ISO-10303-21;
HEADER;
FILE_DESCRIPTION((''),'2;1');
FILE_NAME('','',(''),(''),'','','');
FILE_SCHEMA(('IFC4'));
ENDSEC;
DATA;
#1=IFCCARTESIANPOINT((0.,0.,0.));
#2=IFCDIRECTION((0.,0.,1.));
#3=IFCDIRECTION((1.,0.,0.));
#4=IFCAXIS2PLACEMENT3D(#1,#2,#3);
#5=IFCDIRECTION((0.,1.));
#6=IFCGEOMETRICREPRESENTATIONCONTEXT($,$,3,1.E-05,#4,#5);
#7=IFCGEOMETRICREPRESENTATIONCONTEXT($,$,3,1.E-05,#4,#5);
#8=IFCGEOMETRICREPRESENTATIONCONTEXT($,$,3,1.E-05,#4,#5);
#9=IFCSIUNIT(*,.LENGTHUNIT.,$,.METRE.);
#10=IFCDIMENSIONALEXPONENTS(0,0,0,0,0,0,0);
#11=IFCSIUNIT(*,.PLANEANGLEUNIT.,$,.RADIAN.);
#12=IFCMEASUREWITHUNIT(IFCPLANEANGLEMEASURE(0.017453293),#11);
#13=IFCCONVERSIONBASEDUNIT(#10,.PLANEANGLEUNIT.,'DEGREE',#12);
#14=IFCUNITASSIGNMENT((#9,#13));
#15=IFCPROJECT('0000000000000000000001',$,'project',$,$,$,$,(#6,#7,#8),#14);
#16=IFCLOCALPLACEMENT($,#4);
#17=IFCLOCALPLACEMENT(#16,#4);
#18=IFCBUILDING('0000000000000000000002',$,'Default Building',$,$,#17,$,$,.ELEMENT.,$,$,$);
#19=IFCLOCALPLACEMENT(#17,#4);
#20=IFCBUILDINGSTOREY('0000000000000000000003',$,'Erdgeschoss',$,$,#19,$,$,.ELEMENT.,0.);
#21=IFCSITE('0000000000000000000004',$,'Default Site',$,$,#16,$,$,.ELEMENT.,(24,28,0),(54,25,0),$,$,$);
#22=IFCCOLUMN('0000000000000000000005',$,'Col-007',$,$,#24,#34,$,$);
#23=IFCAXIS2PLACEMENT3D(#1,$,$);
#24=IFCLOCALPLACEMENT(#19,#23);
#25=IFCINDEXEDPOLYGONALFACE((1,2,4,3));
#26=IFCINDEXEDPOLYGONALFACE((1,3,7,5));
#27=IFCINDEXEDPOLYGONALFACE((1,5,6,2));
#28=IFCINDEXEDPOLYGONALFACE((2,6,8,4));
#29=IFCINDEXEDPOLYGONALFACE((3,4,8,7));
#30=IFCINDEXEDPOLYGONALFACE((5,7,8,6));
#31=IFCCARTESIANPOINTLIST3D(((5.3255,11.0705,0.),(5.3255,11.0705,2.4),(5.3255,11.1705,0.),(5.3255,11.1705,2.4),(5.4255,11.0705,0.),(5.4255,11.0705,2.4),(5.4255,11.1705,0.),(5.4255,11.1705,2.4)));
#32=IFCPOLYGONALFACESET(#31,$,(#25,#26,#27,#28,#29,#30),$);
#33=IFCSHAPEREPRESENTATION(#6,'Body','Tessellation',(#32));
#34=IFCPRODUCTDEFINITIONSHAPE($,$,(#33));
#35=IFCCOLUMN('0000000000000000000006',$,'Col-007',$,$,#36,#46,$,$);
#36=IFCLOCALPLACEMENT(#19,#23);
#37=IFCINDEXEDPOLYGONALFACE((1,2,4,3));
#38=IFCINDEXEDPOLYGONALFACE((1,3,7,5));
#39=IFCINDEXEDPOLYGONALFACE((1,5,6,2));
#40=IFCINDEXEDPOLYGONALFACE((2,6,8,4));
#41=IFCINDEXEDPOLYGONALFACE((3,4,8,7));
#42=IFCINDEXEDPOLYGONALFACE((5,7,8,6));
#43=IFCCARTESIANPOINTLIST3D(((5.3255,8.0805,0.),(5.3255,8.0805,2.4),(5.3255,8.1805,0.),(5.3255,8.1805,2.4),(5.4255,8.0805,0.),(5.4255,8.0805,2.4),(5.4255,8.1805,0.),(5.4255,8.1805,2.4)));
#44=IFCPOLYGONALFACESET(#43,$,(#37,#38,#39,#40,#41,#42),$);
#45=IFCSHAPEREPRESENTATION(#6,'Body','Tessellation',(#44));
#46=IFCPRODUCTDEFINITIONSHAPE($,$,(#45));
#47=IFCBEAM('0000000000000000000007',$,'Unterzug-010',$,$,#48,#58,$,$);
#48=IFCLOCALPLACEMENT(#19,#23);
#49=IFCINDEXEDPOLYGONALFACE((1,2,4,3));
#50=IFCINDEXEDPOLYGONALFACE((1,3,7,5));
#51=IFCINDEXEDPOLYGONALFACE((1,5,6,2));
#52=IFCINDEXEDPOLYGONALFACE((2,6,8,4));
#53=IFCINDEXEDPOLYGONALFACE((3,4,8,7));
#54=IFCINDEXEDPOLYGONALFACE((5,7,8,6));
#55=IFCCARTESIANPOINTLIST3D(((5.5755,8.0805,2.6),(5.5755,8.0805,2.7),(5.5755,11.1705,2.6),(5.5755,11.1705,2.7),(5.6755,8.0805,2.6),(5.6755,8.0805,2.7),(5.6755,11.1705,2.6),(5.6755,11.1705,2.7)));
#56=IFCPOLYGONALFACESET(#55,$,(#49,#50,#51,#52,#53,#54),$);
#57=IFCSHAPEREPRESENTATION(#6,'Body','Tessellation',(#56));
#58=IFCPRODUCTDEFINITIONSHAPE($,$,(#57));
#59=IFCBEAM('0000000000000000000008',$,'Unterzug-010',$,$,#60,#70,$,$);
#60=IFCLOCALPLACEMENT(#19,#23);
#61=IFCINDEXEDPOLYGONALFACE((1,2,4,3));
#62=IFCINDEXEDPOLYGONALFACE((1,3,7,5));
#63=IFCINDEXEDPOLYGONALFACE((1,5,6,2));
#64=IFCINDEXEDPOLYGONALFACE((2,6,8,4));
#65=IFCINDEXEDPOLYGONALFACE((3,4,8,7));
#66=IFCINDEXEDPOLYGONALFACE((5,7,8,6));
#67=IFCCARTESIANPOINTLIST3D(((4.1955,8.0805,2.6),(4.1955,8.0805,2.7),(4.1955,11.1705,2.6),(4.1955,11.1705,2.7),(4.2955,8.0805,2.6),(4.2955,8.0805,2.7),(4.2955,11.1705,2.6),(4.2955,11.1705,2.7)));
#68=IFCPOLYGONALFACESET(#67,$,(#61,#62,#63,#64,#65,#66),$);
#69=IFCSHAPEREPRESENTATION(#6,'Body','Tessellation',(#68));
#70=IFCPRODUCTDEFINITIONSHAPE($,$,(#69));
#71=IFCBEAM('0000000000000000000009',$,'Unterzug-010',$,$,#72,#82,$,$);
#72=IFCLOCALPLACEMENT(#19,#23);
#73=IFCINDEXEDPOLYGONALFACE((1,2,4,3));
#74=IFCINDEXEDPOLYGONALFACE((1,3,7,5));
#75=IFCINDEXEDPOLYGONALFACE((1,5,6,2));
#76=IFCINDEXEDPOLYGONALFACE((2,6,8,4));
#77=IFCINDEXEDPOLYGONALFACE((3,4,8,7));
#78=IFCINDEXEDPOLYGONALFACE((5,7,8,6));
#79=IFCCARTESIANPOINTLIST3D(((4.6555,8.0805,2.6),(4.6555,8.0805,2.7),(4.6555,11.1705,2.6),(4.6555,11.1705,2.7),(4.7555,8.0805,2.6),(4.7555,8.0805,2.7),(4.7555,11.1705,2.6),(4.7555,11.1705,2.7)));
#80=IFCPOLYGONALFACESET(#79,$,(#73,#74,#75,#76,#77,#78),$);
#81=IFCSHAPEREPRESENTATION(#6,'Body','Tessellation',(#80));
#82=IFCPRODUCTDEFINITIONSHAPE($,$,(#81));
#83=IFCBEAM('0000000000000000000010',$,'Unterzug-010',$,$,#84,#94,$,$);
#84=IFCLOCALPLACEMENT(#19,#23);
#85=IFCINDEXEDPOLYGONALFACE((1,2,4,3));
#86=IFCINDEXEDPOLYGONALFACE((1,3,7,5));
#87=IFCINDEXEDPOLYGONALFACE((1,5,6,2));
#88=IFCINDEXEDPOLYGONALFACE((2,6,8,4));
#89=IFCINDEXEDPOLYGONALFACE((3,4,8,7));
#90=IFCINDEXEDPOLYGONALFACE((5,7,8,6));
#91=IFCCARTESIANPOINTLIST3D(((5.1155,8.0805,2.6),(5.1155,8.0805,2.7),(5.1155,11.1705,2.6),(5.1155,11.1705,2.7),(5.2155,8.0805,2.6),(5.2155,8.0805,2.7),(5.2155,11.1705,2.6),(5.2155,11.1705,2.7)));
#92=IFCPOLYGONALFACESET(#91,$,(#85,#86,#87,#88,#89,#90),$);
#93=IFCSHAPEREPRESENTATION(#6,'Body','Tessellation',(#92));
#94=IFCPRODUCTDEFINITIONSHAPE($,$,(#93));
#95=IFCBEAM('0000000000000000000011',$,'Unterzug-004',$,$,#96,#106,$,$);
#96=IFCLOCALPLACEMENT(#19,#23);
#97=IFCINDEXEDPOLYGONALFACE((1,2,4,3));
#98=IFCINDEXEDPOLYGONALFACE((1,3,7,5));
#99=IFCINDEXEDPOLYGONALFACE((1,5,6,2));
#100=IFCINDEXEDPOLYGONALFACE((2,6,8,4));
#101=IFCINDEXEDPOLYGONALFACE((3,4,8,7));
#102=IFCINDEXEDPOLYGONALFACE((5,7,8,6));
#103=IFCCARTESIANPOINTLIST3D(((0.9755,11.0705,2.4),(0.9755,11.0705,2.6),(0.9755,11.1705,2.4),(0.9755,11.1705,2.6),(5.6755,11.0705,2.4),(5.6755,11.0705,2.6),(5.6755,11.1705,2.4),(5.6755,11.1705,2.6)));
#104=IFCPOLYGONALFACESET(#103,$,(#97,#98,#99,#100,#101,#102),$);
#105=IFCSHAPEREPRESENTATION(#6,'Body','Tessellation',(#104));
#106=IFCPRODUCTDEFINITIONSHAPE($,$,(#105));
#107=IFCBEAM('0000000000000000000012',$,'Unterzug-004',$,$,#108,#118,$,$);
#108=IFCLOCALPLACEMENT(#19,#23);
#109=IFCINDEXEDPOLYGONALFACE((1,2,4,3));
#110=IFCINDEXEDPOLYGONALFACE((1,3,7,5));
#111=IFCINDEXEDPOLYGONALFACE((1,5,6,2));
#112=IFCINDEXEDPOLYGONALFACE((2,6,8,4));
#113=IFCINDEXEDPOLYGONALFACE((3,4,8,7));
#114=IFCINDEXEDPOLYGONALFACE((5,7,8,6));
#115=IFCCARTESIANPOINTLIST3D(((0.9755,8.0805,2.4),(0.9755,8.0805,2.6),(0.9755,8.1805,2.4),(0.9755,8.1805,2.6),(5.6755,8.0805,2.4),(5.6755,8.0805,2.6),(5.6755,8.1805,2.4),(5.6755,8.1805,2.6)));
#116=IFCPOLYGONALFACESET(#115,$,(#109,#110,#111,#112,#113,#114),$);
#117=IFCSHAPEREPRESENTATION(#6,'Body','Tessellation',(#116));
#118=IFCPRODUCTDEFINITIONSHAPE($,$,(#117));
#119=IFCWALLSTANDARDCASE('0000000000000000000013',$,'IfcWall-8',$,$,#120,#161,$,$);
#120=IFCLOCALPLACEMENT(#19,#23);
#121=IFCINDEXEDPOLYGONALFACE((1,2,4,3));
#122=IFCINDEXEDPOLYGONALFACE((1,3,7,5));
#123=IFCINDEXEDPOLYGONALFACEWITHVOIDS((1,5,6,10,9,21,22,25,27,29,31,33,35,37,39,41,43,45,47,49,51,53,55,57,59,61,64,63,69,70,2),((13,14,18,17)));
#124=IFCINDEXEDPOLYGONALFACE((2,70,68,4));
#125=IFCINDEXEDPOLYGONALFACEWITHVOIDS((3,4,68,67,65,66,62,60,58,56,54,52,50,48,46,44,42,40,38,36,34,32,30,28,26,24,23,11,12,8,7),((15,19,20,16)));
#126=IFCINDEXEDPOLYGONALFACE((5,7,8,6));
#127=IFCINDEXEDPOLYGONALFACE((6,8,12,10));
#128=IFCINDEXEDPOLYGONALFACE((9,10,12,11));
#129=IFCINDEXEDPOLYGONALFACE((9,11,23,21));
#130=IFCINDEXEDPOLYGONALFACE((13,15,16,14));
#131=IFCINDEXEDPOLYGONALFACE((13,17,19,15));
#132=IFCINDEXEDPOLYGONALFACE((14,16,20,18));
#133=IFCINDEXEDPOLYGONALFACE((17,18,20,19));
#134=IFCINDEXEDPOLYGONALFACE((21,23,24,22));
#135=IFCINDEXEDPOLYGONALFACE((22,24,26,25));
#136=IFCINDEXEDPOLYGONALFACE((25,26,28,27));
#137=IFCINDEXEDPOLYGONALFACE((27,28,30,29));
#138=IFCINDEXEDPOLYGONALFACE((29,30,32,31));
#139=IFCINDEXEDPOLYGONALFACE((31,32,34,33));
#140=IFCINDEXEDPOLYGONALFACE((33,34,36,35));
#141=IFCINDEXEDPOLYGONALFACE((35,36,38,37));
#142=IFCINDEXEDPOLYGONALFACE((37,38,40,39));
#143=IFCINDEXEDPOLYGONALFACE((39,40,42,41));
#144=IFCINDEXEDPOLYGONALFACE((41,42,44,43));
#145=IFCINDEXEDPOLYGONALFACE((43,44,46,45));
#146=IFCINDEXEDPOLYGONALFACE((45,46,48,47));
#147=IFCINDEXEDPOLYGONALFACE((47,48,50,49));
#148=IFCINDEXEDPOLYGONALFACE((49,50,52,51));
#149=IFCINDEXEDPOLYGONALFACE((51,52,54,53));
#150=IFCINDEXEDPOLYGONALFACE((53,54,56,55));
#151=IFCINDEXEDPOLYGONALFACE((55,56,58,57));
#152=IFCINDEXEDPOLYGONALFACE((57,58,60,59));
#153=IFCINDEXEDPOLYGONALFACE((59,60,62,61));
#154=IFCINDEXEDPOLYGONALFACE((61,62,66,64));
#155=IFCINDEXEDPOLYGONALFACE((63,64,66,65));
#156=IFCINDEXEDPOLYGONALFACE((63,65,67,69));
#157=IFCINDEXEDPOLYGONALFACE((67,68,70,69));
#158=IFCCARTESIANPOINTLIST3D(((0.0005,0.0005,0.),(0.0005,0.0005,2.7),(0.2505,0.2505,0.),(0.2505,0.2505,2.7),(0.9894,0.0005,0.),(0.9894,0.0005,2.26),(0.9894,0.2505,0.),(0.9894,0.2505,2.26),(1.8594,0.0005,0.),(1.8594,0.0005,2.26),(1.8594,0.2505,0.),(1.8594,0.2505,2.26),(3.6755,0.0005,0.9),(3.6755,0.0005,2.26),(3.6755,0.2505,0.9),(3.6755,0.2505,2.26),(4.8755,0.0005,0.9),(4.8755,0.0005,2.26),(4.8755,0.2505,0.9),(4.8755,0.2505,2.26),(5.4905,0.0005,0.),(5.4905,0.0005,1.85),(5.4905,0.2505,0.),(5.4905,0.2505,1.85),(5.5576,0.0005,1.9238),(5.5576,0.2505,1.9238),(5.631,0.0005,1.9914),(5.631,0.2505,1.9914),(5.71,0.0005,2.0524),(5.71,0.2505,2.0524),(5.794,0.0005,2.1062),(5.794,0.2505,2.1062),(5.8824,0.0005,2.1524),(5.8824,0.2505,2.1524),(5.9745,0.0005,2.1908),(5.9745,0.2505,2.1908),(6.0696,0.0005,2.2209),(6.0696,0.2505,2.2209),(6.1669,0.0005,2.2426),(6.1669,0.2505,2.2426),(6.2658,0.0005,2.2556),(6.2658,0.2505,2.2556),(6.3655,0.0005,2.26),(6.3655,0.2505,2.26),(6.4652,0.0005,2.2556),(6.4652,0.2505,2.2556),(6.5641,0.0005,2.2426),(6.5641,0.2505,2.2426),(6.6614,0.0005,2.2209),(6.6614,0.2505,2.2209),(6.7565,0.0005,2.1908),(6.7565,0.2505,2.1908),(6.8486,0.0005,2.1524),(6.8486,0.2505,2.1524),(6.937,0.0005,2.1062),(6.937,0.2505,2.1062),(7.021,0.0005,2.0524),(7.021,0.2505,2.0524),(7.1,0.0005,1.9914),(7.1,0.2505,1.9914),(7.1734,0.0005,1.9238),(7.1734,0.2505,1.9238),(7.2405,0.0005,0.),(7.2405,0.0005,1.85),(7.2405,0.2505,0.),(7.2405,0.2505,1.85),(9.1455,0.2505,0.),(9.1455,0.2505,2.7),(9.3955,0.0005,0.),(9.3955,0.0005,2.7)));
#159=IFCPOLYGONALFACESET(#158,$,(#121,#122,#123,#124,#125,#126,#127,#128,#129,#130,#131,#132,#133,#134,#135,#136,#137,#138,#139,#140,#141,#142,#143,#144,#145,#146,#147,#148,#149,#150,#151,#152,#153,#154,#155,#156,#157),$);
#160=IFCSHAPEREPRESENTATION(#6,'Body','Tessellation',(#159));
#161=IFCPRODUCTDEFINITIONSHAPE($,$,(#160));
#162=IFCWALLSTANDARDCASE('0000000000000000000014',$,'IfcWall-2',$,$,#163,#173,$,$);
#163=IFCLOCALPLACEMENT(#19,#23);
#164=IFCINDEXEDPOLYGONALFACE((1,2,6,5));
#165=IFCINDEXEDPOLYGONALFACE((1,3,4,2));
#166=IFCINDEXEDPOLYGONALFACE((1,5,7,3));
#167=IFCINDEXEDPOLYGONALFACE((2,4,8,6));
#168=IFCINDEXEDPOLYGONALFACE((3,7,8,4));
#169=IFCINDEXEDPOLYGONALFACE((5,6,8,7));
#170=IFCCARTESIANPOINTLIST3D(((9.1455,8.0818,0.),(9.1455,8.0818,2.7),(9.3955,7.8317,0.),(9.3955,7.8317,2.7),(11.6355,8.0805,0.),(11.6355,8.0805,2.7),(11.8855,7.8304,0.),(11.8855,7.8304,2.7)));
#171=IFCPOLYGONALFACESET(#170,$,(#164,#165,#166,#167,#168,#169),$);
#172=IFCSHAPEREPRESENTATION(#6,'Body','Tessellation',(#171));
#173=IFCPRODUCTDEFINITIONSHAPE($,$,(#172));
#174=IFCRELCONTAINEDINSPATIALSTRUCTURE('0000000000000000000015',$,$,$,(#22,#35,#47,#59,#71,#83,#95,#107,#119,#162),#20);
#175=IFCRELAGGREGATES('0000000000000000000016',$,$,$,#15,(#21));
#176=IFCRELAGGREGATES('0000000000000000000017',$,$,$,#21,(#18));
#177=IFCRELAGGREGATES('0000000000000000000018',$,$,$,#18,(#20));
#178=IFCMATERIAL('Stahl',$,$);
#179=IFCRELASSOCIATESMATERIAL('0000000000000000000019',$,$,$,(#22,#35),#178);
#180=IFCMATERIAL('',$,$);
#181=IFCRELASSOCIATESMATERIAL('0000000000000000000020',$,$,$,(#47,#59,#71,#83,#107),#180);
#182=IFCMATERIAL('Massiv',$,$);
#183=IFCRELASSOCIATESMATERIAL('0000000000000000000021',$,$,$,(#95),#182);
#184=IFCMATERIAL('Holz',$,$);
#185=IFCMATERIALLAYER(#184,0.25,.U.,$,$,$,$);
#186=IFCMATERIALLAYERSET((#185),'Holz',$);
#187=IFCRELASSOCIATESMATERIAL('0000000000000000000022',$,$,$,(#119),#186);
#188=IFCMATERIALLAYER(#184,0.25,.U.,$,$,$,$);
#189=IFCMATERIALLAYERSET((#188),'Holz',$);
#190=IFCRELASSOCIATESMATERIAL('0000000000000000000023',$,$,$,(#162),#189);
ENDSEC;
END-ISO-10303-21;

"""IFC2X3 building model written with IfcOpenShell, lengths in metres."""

from ifc_helpers import new_model, entity, si_unit, converted_unit, direction, frame, frame_2d, origin_with_axes, place, context, project, spatial, polyline, rectangle, outline, extrude, material, layer, layer_set, layer_usage, element, save


model = new_model("IFC2X3")

# Units and contexts
context_of_model_1 = context(None, 3, precision=1e-05, world=origin_with_axes(), true_north=direction((0.0, 1.0)))
context_of_model_2 = context(None, 3, precision=1e-05, world=origin_with_axes(), true_north=direction((0.0, 1.0)))
context_of_model_3 = context(None, 3, precision=1e-05, world=origin_with_axes(), true_north=direction((0.0, 1.0)))
ifc_project = project(units=[si_unit("LENGTHUNIT", "METRE"), converted_unit("PLANEANGLEUNIT", "DEGREE", entity("IfcPlaneAngleMeasure", 0.017453293), si_unit("PLANEANGLEUNIT", "RADIAN"), dimensions=[0, 0, 0, 0, 0, 0, 0])], contexts=[context_of_model_1, context_of_model_2, context_of_model_3])

# Site, building, storey
site_placement = place(None, origin_with_axes())
site = spatial("IfcSite", under=ifc_project, at=site_placement, Name="Default Site", CompositionType="ELEMENT", RefLatitude=(24, 28, 0), RefLongitude=(54, 25, 0))
building_placement = place(site_placement, origin_with_axes())
building = spatial("IfcBuilding", under=site, at=building_placement, Name="Default Building", CompositionType="ELEMENT")
storey_placement = place(building_placement, origin_with_axes())
storey = spatial("IfcBuildingStorey", under=building, at=storey_placement, Name="Erdgeschoss", CompositionType="ELEMENT", Elevation=0.0)

# Columns
ifc_material_1 = material(Name="Stahl")
for number, where, z_axis, x_axis, name in (
    (1, (5.3755, 11.1205, 0.0), (0.0, 0.0, 1.0), (1.0, 0.0, 0.0), "Col-007"),
    (2, (5.3755, 8.1305, 0.0), (0.0, 0.0, 1.0), (1.0, 0.0, 0.0), "Col-007"),
):
    element("IfcColumn", number, at=place(storey_placement, frame(where, z_axis=z_axis, x_axis=x_axis)), inside=storey, material=ifc_material_1, Name=name, context=context_of_model_1, shape_type="SweptSolid", body=[
        extrude(outline(polyline([(-0.05, -0.05), (0.05, -0.05), (0.05, 0.05), (-0.05, 0.05), (-0.05, -0.05)])), origin_with_axes(), (0.0, 0.0, 1.0), 2.4),
    ])

# Beams
ifc_material_2 = material(Name="")
for number, where, z_axis, x_axis, name in (
    (3, (5.6255, 8.0805, 2.7), (0.0, 0.0, 1.0), (1.0, 0.0, 0.0), "Unterzug-010"),
    (4, (4.2455, 8.0805, 2.7), (0.0, 0.0, 1.0), (1.0, 0.0, 0.0), "Unterzug-010"),
    (5, (4.7055, 8.0805, 2.7), (0.0, 0.0, 1.0), (1.0, 0.0, 0.0), "Unterzug-010"),
    (6, (5.1655, 8.0805, 2.7), (0.0, 0.0, 1.0), (1.0, 0.0, 0.0), "Unterzug-010"),
):
    element("IfcBeam", number, at=place(storey_placement, frame(where, z_axis=z_axis, x_axis=x_axis)), inside=storey, material=ifc_material_2, Name=name, context=context_of_model_1, shape_type="SweptSolid", body=[
        extrude(outline(polyline([(-0.1, -0.05), (0.0, -0.05), (0.0, 0.05), (-0.1, 0.05), (-0.1, -0.05)])), frame((0.0, 0.0, 0.0), z_axis=(0.0, 1.0, 0.0), x_axis=(0.0, 0.0, 1.0)), (0.0, 0.0, 1.0), 3.09),
    ])
ifc_material_3 = material(Name="Massiv")
beam_1_placement = place(storey_placement, frame((5.6755, 11.1205, 2.6), z_axis=(0.0, 0.0, 1.0), x_axis=(0.0, 1.0, 0.0)))
element("IfcBeam", 7, at=beam_1_placement, inside=storey, material=ifc_material_3, Name="Unterzug-004", context=context_of_model_1, shape_type="SweptSolid", body=[
    extrude(outline(polyline([(-0.2, -0.05), (0.0, -0.05), (0.0, 0.05), (-0.2, 0.05), (-0.2, -0.05)])), frame((0.0, 0.0, 0.0), z_axis=(0.0, 1.0, 0.0), x_axis=(0.0, 0.0, 1.0)), (0.0, 0.0, 1.0), 4.7),
])
beam_2_placement = place(storey_placement, frame((5.6755, 8.1305, 2.6), z_axis=(0.0, 0.0, 1.0), x_axis=(0.0, 1.0, 0.0)))
element("IfcBeam", 8, at=beam_2_placement, inside=storey, material=ifc_material_2, Name="Unterzug-004", context=context_of_model_1, shape_type="SweptSolid", body=[
    extrude(outline(polyline([(-0.2, -0.05), (0.0, -0.05), (0.0, 0.05), (-0.2, 0.05), (-0.2, -0.05)])), frame((0.0, 0.0, 0.0), z_axis=(0.0, 1.0, 0.0), x_axis=(0.0, 0.0, 1.0)), (0.0, 0.0, 1.0), 4.7),
])

# Wall, openings
ifc_material_4 = material(Name="Holz")
ifc_layer_1 = layer(ifc_material_4, 0.25, ventilated="UNKNOWN")
ifc_layer_set_1 = layer_set([ifc_layer_1], Name="Holz")
ifc_layer_usage_1 = layer_usage(ifc_layer_set_1, "AXIS2", "NEGATIVE", 0.0)
wall_1_placement = place(storey_placement, frame((9.3955, 0.0005, 0.0), z_axis=(0.0, 0.0, 1.0), x_axis=(-1.0, 0.0, 0.0)))
wall_1 = element("IfcWallStandardCase", 9, at=wall_1_placement, inside=storey, material=ifc_layer_usage_1, Name="IfcWall-8", context=context_of_model_1, shape_type="SweptSolid", body=[
    extrude(outline(polyline([(0.25, -0.25), (9.145, -0.25), (9.395, 0.0), (0.0, 0.0), (0.25, -0.25)])), origin_with_axes(), (0.0, 0.0, 1.0), 2.7),
])
opening_1_placement = place(wall_1_placement, frame((7.9711, -0.25, 0.0), z_axis=(0.0, 0.0, 1.0), x_axis=(1.0, 0.0, 0.0)))
element("IfcOpeningElement", 10, at=opening_1_placement, cuts=wall_1, context=context_of_model_1, shape_type="SweptSolid", body=[
    extrude(rectangle(XDim=2.26, YDim=0.87, at=frame_2d((0.0, 1.13), x_axis=(0.0, -1.0))), frame((0.0, 0.0, 0.0), z_axis=(0.0, 1.0, 0.0), x_axis=(-1.0, 0.0, 0.0)), (0.0, 0.0, 1.0), 0.25),
])
opening_2_placement = place(wall_1_placement, frame((3.03, -0.25, 0.0), z_axis=(0.0, 0.0, 1.0), x_axis=(1.0, 0.0, 0.0)))
element("IfcOpeningElement", 11, at=opening_2_placement, cuts=wall_1, context=context_of_model_1, shape_type="SweptSolid", body=[
    extrude(outline(polyline([(0.875, 1.85), (0.8079, 1.9238), (0.7345, 1.9914), (0.6555, 2.0524), (0.5715, 2.1062), (0.4831, 2.1524), (0.391, 2.1908), (0.2959, 2.2209), (0.1986, 2.2426), (0.0997, 2.2556), (0.0, 2.26), (-0.0997, 2.2556), (-0.1986, 2.2426), (-0.2959, 2.2209), (-0.391, 2.1908), (-0.4831, 2.1524), (-0.5715, 2.1062), (-0.6555, 2.0524), (-0.7345, 1.9914), (-0.8079, 1.9238), (-0.875, 1.85), (-0.875, 0.0), (0.875, 0.0), (0.875, 1.85)])), frame((0.0, 0.0, 0.0), z_axis=(0.0, 1.0, 0.0), x_axis=(-1.0, 0.0, 0.0)), (0.0, 0.0, 1.0), 0.25),
])
opening_3_placement = place(wall_1_placement, frame((5.12, -0.25, 0.9), z_axis=(0.0, 0.0, 1.0), x_axis=(1.0, 0.0, 0.0)))
element("IfcOpeningElement", 12, at=opening_3_placement, cuts=wall_1, context=context_of_model_1, shape_type="SweptSolid", body=[
    extrude(rectangle(XDim=1.36, YDim=1.2, at=frame_2d((0.0, 0.68), x_axis=(0.0, -1.0))), frame((0.0, 0.0, 0.0), z_axis=(0.0, 1.0, 0.0), x_axis=(-1.0, 0.0, 0.0)), (0.0, 0.0, 1.0), 0.25),
])

# Wall
ifc_layer_2 = layer(ifc_material_4, 0.25, ventilated="UNKNOWN")
ifc_layer_set_2 = layer_set([ifc_layer_2], Name="Holz")
ifc_layer_usage_2 = layer_usage(ifc_layer_set_2, "AXIS2", "NEGATIVE", 0.0)
wall_2_placement = place(storey_placement, frame((9.3955, 8.0817, 0.0), z_axis=(0.0, 0.0, 1.0), x_axis=(1.0, -0.000521, 0.0)))
element("IfcWallStandardCase", 13, at=wall_2_placement, inside=storey, material=ifc_layer_usage_2, Name="IfcWall-2", context=context_of_model_1, shape_type="SweptSolid", body=[
    extrude(outline(polyline([(0.0001, -0.25), (2.4901, -0.25), (2.24, 0.0), (-0.25, 0.0), (0.0001, -0.25)])), origin_with_axes(), (0.0, 0.0, 1.0), 2.7),
])

save(model, "model.ifc")
